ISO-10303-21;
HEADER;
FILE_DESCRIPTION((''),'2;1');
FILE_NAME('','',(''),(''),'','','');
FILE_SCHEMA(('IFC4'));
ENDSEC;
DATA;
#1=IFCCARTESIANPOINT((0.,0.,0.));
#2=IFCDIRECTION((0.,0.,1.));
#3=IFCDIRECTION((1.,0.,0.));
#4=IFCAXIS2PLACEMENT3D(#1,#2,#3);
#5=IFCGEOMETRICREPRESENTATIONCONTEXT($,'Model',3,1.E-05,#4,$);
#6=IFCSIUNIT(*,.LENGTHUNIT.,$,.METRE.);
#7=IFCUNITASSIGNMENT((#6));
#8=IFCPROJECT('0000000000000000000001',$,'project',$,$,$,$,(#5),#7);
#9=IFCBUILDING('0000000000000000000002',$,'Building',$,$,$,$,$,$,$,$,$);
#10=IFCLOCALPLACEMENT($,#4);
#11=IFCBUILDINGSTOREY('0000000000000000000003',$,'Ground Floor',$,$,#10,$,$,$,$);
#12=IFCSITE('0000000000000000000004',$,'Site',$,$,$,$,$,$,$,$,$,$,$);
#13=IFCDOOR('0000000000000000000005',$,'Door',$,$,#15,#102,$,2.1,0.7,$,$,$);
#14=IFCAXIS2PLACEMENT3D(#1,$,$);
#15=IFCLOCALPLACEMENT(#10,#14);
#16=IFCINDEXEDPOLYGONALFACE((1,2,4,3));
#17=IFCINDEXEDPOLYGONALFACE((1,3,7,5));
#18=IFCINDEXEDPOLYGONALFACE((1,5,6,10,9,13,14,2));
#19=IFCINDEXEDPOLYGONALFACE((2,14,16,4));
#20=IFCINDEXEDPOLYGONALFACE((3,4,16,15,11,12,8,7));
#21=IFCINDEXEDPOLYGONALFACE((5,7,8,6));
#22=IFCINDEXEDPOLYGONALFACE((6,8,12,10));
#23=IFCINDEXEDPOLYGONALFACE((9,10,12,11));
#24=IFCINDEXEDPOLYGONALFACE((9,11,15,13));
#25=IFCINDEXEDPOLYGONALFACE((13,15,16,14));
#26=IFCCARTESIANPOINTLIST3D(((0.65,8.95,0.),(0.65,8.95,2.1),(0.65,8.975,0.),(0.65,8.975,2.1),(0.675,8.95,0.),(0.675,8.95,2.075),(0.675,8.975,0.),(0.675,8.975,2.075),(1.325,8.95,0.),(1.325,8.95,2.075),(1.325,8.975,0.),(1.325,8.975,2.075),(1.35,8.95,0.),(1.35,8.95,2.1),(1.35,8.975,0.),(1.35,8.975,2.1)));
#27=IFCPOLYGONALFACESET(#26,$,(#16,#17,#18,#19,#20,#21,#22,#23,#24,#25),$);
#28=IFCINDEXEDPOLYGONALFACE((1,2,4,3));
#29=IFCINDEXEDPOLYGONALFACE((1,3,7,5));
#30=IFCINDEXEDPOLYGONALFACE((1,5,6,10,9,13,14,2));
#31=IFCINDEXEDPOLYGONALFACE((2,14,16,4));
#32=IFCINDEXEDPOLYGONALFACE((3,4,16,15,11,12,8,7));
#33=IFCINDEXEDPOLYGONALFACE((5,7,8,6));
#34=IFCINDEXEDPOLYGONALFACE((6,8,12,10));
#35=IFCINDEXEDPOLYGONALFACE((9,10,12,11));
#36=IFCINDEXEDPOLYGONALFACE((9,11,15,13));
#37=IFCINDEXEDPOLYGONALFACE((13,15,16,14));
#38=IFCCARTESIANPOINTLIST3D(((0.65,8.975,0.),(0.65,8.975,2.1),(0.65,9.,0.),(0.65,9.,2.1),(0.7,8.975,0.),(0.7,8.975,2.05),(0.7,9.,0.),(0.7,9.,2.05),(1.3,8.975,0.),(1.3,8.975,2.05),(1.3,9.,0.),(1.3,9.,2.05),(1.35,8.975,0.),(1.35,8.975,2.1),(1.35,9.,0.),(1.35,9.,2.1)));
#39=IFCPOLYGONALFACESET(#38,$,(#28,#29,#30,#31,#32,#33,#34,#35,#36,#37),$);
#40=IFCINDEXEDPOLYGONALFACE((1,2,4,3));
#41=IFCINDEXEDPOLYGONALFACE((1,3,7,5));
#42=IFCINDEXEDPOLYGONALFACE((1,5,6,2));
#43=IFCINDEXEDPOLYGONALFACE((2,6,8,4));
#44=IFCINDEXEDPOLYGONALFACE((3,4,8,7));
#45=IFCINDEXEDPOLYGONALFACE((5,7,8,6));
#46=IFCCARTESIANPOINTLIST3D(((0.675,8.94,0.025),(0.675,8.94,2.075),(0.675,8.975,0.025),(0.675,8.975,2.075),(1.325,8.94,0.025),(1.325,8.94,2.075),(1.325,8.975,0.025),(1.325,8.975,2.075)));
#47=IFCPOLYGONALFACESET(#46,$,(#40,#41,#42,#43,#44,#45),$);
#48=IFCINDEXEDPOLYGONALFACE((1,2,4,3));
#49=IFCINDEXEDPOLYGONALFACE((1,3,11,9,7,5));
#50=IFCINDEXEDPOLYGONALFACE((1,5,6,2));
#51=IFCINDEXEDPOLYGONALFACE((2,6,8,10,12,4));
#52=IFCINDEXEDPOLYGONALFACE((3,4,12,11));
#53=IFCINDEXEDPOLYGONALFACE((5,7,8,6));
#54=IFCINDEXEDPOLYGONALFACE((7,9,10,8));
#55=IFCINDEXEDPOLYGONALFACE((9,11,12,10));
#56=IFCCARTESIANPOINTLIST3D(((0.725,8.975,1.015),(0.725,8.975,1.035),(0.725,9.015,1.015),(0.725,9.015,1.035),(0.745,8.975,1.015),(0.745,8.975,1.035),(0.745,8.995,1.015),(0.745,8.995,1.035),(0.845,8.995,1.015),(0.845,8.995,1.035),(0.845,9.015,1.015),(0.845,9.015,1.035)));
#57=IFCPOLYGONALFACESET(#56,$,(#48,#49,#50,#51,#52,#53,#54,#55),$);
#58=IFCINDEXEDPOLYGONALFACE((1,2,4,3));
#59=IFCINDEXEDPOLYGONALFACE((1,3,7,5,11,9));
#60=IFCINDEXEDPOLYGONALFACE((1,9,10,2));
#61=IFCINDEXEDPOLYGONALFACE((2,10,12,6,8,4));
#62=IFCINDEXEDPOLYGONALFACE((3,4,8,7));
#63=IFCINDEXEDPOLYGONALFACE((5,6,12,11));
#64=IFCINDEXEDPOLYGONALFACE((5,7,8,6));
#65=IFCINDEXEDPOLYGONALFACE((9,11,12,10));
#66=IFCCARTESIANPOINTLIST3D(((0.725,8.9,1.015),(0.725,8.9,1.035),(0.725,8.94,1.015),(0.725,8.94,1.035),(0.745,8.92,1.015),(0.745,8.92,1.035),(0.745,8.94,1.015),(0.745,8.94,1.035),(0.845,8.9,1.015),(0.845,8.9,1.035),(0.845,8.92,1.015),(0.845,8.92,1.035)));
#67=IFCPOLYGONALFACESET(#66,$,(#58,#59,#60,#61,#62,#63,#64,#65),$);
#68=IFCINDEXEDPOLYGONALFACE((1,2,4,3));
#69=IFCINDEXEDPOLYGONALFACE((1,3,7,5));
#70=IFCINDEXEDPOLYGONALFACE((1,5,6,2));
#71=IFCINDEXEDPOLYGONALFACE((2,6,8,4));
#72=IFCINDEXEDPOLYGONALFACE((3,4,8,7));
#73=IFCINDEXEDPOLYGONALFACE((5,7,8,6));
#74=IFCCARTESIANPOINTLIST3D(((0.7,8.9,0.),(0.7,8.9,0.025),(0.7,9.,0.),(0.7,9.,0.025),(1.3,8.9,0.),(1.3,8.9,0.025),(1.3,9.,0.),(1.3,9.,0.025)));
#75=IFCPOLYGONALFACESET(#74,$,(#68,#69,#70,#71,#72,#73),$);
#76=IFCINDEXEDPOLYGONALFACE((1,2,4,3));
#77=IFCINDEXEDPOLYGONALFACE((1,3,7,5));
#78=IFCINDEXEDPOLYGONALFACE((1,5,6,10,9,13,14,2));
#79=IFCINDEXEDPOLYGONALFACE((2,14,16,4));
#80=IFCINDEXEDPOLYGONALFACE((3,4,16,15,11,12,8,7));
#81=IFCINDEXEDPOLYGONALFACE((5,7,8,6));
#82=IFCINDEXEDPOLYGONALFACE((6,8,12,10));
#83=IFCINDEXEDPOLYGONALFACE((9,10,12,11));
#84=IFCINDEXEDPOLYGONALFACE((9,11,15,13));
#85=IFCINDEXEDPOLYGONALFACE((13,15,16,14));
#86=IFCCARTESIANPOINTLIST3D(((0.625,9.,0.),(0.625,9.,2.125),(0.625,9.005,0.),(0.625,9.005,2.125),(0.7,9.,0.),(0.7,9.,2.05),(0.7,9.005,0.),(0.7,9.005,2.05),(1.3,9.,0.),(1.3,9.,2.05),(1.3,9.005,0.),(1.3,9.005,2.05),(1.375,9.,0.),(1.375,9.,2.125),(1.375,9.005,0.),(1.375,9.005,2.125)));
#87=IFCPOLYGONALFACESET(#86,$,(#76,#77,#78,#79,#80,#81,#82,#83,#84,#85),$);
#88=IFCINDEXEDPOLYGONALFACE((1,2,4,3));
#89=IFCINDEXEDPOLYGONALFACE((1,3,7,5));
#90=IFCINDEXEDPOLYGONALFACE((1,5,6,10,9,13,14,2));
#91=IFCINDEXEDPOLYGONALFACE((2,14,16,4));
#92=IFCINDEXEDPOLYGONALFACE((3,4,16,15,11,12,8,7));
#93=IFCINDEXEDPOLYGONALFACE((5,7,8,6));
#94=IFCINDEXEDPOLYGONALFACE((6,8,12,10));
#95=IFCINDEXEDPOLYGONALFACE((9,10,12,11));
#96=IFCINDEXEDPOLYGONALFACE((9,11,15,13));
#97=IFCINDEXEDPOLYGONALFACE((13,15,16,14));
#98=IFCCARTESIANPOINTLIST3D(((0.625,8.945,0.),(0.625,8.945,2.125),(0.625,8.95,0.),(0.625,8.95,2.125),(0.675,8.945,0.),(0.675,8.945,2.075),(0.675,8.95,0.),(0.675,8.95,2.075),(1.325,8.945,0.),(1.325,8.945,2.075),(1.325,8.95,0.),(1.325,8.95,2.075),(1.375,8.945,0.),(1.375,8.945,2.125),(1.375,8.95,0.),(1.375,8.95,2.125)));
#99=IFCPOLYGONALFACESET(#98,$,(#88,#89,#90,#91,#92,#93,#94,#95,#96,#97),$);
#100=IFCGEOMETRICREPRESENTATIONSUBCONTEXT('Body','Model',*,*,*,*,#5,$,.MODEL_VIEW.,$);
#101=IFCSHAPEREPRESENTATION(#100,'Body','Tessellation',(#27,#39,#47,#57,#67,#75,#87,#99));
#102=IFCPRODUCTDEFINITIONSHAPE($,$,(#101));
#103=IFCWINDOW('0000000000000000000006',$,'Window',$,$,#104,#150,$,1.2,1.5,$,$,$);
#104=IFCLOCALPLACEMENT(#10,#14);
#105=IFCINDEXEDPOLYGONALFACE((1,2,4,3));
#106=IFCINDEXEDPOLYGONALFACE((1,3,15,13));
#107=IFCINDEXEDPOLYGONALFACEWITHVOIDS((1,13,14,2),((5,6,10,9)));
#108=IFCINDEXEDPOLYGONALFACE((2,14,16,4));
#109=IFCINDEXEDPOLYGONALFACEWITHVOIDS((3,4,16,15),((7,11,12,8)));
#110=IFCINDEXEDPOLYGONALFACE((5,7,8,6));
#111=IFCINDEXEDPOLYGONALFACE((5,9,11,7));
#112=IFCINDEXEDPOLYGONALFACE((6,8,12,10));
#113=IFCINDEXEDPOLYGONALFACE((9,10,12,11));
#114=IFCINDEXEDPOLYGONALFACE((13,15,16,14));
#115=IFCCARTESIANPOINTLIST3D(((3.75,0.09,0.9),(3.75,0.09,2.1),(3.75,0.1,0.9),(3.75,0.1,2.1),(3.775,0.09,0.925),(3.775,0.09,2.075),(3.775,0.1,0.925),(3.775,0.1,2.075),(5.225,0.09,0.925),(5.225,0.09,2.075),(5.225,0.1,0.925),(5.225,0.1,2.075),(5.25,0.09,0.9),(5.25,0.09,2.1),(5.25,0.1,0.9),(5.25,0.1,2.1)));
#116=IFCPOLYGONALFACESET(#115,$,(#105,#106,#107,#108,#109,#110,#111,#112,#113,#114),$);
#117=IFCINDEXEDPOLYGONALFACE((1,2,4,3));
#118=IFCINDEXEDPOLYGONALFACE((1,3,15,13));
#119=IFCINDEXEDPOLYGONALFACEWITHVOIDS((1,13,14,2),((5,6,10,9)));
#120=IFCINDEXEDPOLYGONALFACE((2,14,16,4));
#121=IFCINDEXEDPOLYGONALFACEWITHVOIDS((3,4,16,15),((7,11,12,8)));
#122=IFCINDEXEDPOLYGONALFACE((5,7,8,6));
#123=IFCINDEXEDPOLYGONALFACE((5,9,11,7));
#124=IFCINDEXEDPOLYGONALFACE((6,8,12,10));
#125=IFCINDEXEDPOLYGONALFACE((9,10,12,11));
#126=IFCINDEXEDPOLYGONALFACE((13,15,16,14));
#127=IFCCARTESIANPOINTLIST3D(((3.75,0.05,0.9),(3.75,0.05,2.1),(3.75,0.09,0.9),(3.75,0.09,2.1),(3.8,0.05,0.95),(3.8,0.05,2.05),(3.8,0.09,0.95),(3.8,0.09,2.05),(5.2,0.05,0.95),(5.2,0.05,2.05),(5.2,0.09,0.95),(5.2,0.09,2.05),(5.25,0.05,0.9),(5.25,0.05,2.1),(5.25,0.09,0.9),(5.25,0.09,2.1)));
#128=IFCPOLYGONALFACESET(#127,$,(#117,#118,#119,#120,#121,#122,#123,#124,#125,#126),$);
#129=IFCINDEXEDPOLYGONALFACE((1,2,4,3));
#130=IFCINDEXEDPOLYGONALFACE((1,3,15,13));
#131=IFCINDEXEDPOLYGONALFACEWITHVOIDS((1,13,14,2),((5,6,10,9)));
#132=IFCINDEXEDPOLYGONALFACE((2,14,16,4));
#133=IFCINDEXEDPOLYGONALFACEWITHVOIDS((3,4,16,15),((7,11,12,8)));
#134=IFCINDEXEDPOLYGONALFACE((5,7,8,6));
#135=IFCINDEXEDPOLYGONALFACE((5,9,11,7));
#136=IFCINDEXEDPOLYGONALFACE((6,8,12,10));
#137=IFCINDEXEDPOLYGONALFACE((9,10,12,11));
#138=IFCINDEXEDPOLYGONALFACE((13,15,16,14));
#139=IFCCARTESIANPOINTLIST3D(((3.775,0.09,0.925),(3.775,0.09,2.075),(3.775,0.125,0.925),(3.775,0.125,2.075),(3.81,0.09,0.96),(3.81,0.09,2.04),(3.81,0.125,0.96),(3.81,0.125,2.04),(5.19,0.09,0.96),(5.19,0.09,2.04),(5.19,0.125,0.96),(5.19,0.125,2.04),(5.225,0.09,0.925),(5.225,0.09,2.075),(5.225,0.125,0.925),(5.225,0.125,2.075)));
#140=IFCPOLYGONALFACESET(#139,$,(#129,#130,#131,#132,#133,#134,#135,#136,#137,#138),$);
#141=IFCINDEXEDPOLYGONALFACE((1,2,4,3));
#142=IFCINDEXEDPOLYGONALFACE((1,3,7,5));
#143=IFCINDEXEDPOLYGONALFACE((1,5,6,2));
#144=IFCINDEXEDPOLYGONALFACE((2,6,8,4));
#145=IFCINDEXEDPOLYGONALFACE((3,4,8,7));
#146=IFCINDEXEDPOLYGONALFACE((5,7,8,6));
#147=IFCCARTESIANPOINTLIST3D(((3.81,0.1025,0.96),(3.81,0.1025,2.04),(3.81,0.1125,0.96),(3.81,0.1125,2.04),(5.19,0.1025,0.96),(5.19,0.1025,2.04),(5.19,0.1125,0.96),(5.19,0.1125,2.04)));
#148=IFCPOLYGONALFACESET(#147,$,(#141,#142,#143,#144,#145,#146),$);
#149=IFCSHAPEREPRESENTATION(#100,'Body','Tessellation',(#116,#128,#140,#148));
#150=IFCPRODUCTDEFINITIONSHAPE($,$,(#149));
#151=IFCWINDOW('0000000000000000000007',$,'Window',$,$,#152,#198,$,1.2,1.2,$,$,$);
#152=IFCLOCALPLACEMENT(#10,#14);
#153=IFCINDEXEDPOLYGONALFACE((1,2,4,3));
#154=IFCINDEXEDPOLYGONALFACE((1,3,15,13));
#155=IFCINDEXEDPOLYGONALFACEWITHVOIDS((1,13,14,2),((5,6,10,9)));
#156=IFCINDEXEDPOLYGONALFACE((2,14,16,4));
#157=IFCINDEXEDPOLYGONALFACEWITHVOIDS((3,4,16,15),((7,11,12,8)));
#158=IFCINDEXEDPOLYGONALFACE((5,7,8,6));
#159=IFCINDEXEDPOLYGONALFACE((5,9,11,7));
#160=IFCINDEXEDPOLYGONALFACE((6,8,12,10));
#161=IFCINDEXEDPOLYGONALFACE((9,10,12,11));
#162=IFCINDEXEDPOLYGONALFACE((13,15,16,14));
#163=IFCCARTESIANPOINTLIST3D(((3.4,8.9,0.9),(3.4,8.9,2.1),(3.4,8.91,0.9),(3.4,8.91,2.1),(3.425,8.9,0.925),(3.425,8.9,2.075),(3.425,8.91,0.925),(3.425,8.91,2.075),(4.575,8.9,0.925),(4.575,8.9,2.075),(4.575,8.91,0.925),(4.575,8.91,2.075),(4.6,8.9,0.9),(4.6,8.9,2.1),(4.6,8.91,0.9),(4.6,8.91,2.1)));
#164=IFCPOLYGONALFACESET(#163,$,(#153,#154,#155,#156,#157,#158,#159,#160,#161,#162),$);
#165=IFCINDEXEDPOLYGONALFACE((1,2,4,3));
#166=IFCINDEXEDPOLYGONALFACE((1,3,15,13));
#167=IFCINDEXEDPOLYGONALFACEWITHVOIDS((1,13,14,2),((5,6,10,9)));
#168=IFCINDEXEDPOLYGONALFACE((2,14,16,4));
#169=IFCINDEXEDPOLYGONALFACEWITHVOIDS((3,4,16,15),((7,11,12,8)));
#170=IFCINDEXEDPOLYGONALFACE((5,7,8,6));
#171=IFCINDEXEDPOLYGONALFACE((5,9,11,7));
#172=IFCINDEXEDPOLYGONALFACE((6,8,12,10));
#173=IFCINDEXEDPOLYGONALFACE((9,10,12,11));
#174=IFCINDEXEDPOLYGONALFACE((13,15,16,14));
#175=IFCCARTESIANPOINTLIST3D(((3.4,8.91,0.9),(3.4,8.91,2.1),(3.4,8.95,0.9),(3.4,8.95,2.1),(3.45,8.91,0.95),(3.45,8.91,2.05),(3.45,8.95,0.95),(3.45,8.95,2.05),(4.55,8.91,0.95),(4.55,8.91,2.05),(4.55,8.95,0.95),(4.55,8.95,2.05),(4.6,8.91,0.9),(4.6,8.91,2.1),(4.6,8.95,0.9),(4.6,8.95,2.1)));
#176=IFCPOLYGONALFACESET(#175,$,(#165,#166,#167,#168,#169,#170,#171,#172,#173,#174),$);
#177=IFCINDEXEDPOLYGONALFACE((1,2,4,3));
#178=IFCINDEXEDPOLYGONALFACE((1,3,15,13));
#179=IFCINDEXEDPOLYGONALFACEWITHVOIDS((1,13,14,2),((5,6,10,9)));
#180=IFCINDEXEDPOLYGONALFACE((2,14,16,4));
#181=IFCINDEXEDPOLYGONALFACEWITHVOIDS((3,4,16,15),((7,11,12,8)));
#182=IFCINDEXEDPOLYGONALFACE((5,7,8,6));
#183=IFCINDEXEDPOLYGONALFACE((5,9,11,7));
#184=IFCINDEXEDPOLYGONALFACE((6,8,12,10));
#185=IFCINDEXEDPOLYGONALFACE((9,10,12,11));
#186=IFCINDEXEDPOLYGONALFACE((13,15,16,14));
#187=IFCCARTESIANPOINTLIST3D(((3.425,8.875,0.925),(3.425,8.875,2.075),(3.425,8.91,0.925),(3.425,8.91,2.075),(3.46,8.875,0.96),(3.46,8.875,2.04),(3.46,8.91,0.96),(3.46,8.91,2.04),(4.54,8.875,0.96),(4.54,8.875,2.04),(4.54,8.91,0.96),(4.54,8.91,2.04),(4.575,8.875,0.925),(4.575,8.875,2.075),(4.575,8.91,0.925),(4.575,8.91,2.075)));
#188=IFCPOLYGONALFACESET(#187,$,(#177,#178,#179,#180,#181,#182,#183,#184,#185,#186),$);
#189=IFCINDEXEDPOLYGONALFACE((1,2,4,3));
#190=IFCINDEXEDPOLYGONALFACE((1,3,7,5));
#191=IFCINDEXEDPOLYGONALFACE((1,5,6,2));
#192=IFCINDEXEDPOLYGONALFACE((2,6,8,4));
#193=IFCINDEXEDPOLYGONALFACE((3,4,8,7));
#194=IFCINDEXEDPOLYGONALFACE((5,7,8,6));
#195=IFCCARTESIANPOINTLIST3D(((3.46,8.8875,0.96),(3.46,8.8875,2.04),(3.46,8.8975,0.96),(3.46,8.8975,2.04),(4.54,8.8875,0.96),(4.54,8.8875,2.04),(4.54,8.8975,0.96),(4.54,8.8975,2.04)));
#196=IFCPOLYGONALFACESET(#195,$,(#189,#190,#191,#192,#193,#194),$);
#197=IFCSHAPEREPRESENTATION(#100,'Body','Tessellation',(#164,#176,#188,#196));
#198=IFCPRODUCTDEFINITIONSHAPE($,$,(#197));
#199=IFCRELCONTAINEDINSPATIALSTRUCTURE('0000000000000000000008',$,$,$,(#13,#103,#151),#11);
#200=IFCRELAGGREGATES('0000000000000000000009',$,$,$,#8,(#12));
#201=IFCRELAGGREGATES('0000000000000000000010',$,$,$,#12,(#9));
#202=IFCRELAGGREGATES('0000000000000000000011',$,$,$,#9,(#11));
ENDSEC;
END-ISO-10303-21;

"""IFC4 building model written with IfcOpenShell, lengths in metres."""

from ifc_helpers import new_model, si_unit, frame, origin_with_axes, place, context, subcontext, project, spatial, line, indexed_curve, outline, extrude, element, save


model = new_model("IFC4")

# Units and contexts
model_context = context("Model", 3, precision=1e-05, world=origin_with_axes())
body_context = subcontext(model_context, "Body", "Model", "MODEL_VIEW")
ifc_project = project(units=[si_unit("LENGTHUNIT", "METRE")], contexts=[model_context])

# Site, building, storey
site = spatial("IfcSite", under=ifc_project, Name="Site")
building = spatial("IfcBuilding", under=site, Name="Building")
storey_placement = place(None, origin_with_axes())
storey = spatial("IfcBuildingStorey", under=building, at=storey_placement, Name="Ground Floor")

# Door
door_1_placement = place(storey_placement, frame((1.35, 9.0, 0.0), z_axis=(0.0, 0.0, 1.0), x_axis=(-1.0, 0.0, 0.0)))
element("IfcDoor", 1, at=door_1_placement, inside=storey, Name="Door", OverallHeight=2.1, OverallWidth=0.7, context=body_context, shape_type="SweptSolid", body=[
    extrude(outline(indexed_curve([(0.0, 0.0), (0.0, 2.1), (0.7, 2.1), (0.7, 0.0), (0.675, 0.0), (0.675, 2.075), (0.025, 2.075), (0.025, 0.0)], segments=[line(1, 2, 3, 4, 5, 6, 7, 8, 1)])), frame((0.0, 0.025, 0.0), z_axis=(0.0, -1.0, 0.0), x_axis=(1.0, 0.0, 0.0)), (0.0, 0.0, -1.0), 0.025),
    extrude(outline(indexed_curve([(0.0, 0.0), (0.0, 2.1), (0.7, 2.1), (0.7, 0.0), (0.65, 0.0), (0.65, 2.05), (0.05, 2.05), (0.05, 0.0)], segments=[line(1, 2, 3, 4, 5, 6, 7, 8, 1)])), frame((0.0, 0.0, 0.0), z_axis=(0.0, -1.0, 0.0), x_axis=(1.0, 0.0, 0.0)), (0.0, 0.0, -1.0), 0.025),
    extrude(outline(indexed_curve([(0.0, 0.0), (0.65, 0.0), (0.65, 0.035), (0.0, 0.035)], segments=[line(1, 2, 3, 4, 1)])), frame((0.025, 0.025, 0.025), z_axis=(0.0, 0.0, 1.0), x_axis=(1.0, 0.0, 0.0)), (0.0, 0.0, 1.0), 2.05),
    extrude(outline(indexed_curve([(0.0, 0.0), (0.0, -0.04), (-0.12, -0.04), (-0.12, -0.02), (-0.02, -0.02), (-0.02, 0.0)], segments=[line(1, 2, 3, 4, 5, 6, 1)])), frame((0.625, 0.025, 1.015), z_axis=(0.0, 0.0, 1.0), x_axis=(1.0, 0.0, 0.0)), (0.0, 0.0, 1.0), 0.02),
    extrude(outline(indexed_curve([(0.0, 0.0), (0.0, 0.04), (-0.12, 0.04), (-0.12, 0.02), (-0.02, 0.02), (-0.02, 0.0)], segments=[line(1, 2, 3, 4, 5, 6, 1)])), frame((0.625, 0.06, 1.015), z_axis=(0.0, 0.0, 1.0), x_axis=(1.0, 0.0, 0.0)), (0.0, 0.0, 1.0), 0.02),
    extrude(outline(indexed_curve([(0.0, 0.0), (0.6, 0.0), (0.6, 0.1), (0.0, 0.1)], segments=[line(1, 2, 3, 4, 1)])), frame((0.05, 0.0, 0.0), z_axis=(0.0, 0.0, 1.0), x_axis=(1.0, 0.0, 0.0)), (0.0, 0.0, 1.0), 0.025),
    extrude(outline(indexed_curve([(0.0, 0.0), (0.0, 2.125), (0.75, 2.125), (0.75, 0.0), (0.675, 0.0), (0.675, 2.05), (0.075, 2.05), (0.075, 0.0)], segments=[line(1, 2, 3, 4, 5, 6, 7, 8, 1)])), frame((-0.025, -0.005, 0.0), z_axis=(0.0, -1.0, 0.0), x_axis=(1.0, 0.0, 0.0)), (0.0, 0.0, -1.0), 0.005),
    extrude(outline(indexed_curve([(0.0, 0.0), (0.0, 2.125), (0.75, 2.125), (0.75, 0.0), (0.7, 0.0), (0.7, 2.075), (0.05, 2.075), (0.05, 0.0)], segments=[line(1, 2, 3, 4, 5, 6, 7, 8, 1)])), frame((-0.025, 0.05, 0.0), z_axis=(0.0, -1.0, 0.0), x_axis=(1.0, 0.0, 0.0)), (0.0, 0.0, -1.0), 0.005),
])

# Windows
window_1_placement = place(storey_placement, frame((3.75, 0.0, 0.9), z_axis=(0.0, 0.0, 1.0), x_axis=(1.0, 0.0, 0.0)))
element("IfcWindow", 2, at=window_1_placement, inside=storey, Name="Window", OverallHeight=1.2, OverallWidth=1.5, context=body_context, shape_type="SweptSolid", body=[
    extrude(outline(indexed_curve([(0.0, 0.0), (1.5, 0.0), (1.5, 1.2), (0.0, 1.2)], segments=[line(1, 2, 3, 4, 1)]), holes=[indexed_curve([(0.025, 0.025), (1.475, 0.025), (1.475, 1.175), (0.025, 1.175)], segments=[line(1, 2, 3, 4, 1)])]), frame((0.0, 0.09, 0.0), z_axis=(0.0, -1.0, 0.0), x_axis=(1.0, 0.0, 0.0)), (0.0, 0.0, -1.0), 0.01),
    extrude(outline(indexed_curve([(0.0, 0.0), (1.5, 0.0), (1.5, 1.2), (0.0, 1.2)], segments=[line(1, 2, 3, 4, 1)]), holes=[indexed_curve([(0.05, 0.05), (1.45, 0.05), (1.45, 1.15), (0.05, 1.15)], segments=[line(1, 2, 3, 4, 1)])]), frame((0.0, 0.05, 0.0), z_axis=(0.0, -1.0, 0.0), x_axis=(1.0, 0.0, 0.0)), (0.0, 0.0, -1.0), 0.04),
    extrude(outline(indexed_curve([(0.0, 0.0), (1.45, 0.0), (1.45, 1.15), (0.0, 1.15)], segments=[line(1, 2, 3, 4, 1)]), holes=[indexed_curve([(0.035, 0.035), (1.415, 0.035), (1.415, 1.115), (0.035, 1.115)], segments=[line(1, 2, 3, 4, 1)])]), frame((0.025, 0.09, 0.025), z_axis=(0.0, -1.0, 0.0), x_axis=(1.0, 0.0, 0.0)), (0.0, 0.0, -1.0), 0.035),
    extrude(outline(indexed_curve([(0.035, 0.035), (1.415, 0.035), (1.415, 1.115), (0.035, 1.115)], segments=[line(1, 2, 3, 4, 1)])), frame((0.025, 0.1025, 0.025), z_axis=(0.0, -1.0, 0.0), x_axis=(1.0, 0.0, 0.0)), (0.0, 0.0, -1.0), 0.01),
])
window_2_placement = place(storey_placement, frame((4.6, 9.0, 0.9), z_axis=(0.0, 0.0, 1.0), x_axis=(-1.0, 0.0, 0.0)))
element("IfcWindow", 3, at=window_2_placement, inside=storey, Name="Window", OverallHeight=1.2, OverallWidth=1.2, context=body_context, shape_type="SweptSolid", body=[
    extrude(outline(indexed_curve([(0.0, 0.0), (1.2, 0.0), (1.2, 1.2), (0.0, 1.2)], segments=[line(1, 2, 3, 4, 1)]), holes=[indexed_curve([(0.025, 0.025), (1.175, 0.025), (1.175, 1.175), (0.025, 1.175)], segments=[line(1, 2, 3, 4, 1)])]), frame((0.0, 0.09, 0.0), z_axis=(0.0, -1.0, 0.0), x_axis=(1.0, 0.0, 0.0)), (0.0, 0.0, -1.0), 0.01),
    extrude(outline(indexed_curve([(0.0, 0.0), (1.2, 0.0), (1.2, 1.2), (0.0, 1.2)], segments=[line(1, 2, 3, 4, 1)]), holes=[indexed_curve([(0.05, 0.05), (1.15, 0.05), (1.15, 1.15), (0.05, 1.15)], segments=[line(1, 2, 3, 4, 1)])]), frame((0.0, 0.05, 0.0), z_axis=(0.0, -1.0, 0.0), x_axis=(1.0, 0.0, 0.0)), (0.0, 0.0, -1.0), 0.04),
    extrude(outline(indexed_curve([(0.0, 0.0), (1.15, 0.0), (1.15, 1.15), (0.0, 1.15)], segments=[line(1, 2, 3, 4, 1)]), holes=[indexed_curve([(0.035, 0.035), (1.115, 0.035), (1.115, 1.115), (0.035, 1.115)], segments=[line(1, 2, 3, 4, 1)])]), frame((0.025, 0.09, 0.025), z_axis=(0.0, -1.0, 0.0), x_axis=(1.0, 0.0, 0.0)), (0.0, 0.0, -1.0), 0.035),
    extrude(outline(indexed_curve([(0.035, 0.035), (1.115, 0.035), (1.115, 1.115), (0.035, 1.115)], segments=[line(1, 2, 3, 4, 1)])), frame((0.025, 0.1025, 0.025), z_axis=(0.0, -1.0, 0.0), x_axis=(1.0, 0.0, 0.0)), (0.0, 0.0, -1.0), 0.01),
])

save(model, "model.ifc")
